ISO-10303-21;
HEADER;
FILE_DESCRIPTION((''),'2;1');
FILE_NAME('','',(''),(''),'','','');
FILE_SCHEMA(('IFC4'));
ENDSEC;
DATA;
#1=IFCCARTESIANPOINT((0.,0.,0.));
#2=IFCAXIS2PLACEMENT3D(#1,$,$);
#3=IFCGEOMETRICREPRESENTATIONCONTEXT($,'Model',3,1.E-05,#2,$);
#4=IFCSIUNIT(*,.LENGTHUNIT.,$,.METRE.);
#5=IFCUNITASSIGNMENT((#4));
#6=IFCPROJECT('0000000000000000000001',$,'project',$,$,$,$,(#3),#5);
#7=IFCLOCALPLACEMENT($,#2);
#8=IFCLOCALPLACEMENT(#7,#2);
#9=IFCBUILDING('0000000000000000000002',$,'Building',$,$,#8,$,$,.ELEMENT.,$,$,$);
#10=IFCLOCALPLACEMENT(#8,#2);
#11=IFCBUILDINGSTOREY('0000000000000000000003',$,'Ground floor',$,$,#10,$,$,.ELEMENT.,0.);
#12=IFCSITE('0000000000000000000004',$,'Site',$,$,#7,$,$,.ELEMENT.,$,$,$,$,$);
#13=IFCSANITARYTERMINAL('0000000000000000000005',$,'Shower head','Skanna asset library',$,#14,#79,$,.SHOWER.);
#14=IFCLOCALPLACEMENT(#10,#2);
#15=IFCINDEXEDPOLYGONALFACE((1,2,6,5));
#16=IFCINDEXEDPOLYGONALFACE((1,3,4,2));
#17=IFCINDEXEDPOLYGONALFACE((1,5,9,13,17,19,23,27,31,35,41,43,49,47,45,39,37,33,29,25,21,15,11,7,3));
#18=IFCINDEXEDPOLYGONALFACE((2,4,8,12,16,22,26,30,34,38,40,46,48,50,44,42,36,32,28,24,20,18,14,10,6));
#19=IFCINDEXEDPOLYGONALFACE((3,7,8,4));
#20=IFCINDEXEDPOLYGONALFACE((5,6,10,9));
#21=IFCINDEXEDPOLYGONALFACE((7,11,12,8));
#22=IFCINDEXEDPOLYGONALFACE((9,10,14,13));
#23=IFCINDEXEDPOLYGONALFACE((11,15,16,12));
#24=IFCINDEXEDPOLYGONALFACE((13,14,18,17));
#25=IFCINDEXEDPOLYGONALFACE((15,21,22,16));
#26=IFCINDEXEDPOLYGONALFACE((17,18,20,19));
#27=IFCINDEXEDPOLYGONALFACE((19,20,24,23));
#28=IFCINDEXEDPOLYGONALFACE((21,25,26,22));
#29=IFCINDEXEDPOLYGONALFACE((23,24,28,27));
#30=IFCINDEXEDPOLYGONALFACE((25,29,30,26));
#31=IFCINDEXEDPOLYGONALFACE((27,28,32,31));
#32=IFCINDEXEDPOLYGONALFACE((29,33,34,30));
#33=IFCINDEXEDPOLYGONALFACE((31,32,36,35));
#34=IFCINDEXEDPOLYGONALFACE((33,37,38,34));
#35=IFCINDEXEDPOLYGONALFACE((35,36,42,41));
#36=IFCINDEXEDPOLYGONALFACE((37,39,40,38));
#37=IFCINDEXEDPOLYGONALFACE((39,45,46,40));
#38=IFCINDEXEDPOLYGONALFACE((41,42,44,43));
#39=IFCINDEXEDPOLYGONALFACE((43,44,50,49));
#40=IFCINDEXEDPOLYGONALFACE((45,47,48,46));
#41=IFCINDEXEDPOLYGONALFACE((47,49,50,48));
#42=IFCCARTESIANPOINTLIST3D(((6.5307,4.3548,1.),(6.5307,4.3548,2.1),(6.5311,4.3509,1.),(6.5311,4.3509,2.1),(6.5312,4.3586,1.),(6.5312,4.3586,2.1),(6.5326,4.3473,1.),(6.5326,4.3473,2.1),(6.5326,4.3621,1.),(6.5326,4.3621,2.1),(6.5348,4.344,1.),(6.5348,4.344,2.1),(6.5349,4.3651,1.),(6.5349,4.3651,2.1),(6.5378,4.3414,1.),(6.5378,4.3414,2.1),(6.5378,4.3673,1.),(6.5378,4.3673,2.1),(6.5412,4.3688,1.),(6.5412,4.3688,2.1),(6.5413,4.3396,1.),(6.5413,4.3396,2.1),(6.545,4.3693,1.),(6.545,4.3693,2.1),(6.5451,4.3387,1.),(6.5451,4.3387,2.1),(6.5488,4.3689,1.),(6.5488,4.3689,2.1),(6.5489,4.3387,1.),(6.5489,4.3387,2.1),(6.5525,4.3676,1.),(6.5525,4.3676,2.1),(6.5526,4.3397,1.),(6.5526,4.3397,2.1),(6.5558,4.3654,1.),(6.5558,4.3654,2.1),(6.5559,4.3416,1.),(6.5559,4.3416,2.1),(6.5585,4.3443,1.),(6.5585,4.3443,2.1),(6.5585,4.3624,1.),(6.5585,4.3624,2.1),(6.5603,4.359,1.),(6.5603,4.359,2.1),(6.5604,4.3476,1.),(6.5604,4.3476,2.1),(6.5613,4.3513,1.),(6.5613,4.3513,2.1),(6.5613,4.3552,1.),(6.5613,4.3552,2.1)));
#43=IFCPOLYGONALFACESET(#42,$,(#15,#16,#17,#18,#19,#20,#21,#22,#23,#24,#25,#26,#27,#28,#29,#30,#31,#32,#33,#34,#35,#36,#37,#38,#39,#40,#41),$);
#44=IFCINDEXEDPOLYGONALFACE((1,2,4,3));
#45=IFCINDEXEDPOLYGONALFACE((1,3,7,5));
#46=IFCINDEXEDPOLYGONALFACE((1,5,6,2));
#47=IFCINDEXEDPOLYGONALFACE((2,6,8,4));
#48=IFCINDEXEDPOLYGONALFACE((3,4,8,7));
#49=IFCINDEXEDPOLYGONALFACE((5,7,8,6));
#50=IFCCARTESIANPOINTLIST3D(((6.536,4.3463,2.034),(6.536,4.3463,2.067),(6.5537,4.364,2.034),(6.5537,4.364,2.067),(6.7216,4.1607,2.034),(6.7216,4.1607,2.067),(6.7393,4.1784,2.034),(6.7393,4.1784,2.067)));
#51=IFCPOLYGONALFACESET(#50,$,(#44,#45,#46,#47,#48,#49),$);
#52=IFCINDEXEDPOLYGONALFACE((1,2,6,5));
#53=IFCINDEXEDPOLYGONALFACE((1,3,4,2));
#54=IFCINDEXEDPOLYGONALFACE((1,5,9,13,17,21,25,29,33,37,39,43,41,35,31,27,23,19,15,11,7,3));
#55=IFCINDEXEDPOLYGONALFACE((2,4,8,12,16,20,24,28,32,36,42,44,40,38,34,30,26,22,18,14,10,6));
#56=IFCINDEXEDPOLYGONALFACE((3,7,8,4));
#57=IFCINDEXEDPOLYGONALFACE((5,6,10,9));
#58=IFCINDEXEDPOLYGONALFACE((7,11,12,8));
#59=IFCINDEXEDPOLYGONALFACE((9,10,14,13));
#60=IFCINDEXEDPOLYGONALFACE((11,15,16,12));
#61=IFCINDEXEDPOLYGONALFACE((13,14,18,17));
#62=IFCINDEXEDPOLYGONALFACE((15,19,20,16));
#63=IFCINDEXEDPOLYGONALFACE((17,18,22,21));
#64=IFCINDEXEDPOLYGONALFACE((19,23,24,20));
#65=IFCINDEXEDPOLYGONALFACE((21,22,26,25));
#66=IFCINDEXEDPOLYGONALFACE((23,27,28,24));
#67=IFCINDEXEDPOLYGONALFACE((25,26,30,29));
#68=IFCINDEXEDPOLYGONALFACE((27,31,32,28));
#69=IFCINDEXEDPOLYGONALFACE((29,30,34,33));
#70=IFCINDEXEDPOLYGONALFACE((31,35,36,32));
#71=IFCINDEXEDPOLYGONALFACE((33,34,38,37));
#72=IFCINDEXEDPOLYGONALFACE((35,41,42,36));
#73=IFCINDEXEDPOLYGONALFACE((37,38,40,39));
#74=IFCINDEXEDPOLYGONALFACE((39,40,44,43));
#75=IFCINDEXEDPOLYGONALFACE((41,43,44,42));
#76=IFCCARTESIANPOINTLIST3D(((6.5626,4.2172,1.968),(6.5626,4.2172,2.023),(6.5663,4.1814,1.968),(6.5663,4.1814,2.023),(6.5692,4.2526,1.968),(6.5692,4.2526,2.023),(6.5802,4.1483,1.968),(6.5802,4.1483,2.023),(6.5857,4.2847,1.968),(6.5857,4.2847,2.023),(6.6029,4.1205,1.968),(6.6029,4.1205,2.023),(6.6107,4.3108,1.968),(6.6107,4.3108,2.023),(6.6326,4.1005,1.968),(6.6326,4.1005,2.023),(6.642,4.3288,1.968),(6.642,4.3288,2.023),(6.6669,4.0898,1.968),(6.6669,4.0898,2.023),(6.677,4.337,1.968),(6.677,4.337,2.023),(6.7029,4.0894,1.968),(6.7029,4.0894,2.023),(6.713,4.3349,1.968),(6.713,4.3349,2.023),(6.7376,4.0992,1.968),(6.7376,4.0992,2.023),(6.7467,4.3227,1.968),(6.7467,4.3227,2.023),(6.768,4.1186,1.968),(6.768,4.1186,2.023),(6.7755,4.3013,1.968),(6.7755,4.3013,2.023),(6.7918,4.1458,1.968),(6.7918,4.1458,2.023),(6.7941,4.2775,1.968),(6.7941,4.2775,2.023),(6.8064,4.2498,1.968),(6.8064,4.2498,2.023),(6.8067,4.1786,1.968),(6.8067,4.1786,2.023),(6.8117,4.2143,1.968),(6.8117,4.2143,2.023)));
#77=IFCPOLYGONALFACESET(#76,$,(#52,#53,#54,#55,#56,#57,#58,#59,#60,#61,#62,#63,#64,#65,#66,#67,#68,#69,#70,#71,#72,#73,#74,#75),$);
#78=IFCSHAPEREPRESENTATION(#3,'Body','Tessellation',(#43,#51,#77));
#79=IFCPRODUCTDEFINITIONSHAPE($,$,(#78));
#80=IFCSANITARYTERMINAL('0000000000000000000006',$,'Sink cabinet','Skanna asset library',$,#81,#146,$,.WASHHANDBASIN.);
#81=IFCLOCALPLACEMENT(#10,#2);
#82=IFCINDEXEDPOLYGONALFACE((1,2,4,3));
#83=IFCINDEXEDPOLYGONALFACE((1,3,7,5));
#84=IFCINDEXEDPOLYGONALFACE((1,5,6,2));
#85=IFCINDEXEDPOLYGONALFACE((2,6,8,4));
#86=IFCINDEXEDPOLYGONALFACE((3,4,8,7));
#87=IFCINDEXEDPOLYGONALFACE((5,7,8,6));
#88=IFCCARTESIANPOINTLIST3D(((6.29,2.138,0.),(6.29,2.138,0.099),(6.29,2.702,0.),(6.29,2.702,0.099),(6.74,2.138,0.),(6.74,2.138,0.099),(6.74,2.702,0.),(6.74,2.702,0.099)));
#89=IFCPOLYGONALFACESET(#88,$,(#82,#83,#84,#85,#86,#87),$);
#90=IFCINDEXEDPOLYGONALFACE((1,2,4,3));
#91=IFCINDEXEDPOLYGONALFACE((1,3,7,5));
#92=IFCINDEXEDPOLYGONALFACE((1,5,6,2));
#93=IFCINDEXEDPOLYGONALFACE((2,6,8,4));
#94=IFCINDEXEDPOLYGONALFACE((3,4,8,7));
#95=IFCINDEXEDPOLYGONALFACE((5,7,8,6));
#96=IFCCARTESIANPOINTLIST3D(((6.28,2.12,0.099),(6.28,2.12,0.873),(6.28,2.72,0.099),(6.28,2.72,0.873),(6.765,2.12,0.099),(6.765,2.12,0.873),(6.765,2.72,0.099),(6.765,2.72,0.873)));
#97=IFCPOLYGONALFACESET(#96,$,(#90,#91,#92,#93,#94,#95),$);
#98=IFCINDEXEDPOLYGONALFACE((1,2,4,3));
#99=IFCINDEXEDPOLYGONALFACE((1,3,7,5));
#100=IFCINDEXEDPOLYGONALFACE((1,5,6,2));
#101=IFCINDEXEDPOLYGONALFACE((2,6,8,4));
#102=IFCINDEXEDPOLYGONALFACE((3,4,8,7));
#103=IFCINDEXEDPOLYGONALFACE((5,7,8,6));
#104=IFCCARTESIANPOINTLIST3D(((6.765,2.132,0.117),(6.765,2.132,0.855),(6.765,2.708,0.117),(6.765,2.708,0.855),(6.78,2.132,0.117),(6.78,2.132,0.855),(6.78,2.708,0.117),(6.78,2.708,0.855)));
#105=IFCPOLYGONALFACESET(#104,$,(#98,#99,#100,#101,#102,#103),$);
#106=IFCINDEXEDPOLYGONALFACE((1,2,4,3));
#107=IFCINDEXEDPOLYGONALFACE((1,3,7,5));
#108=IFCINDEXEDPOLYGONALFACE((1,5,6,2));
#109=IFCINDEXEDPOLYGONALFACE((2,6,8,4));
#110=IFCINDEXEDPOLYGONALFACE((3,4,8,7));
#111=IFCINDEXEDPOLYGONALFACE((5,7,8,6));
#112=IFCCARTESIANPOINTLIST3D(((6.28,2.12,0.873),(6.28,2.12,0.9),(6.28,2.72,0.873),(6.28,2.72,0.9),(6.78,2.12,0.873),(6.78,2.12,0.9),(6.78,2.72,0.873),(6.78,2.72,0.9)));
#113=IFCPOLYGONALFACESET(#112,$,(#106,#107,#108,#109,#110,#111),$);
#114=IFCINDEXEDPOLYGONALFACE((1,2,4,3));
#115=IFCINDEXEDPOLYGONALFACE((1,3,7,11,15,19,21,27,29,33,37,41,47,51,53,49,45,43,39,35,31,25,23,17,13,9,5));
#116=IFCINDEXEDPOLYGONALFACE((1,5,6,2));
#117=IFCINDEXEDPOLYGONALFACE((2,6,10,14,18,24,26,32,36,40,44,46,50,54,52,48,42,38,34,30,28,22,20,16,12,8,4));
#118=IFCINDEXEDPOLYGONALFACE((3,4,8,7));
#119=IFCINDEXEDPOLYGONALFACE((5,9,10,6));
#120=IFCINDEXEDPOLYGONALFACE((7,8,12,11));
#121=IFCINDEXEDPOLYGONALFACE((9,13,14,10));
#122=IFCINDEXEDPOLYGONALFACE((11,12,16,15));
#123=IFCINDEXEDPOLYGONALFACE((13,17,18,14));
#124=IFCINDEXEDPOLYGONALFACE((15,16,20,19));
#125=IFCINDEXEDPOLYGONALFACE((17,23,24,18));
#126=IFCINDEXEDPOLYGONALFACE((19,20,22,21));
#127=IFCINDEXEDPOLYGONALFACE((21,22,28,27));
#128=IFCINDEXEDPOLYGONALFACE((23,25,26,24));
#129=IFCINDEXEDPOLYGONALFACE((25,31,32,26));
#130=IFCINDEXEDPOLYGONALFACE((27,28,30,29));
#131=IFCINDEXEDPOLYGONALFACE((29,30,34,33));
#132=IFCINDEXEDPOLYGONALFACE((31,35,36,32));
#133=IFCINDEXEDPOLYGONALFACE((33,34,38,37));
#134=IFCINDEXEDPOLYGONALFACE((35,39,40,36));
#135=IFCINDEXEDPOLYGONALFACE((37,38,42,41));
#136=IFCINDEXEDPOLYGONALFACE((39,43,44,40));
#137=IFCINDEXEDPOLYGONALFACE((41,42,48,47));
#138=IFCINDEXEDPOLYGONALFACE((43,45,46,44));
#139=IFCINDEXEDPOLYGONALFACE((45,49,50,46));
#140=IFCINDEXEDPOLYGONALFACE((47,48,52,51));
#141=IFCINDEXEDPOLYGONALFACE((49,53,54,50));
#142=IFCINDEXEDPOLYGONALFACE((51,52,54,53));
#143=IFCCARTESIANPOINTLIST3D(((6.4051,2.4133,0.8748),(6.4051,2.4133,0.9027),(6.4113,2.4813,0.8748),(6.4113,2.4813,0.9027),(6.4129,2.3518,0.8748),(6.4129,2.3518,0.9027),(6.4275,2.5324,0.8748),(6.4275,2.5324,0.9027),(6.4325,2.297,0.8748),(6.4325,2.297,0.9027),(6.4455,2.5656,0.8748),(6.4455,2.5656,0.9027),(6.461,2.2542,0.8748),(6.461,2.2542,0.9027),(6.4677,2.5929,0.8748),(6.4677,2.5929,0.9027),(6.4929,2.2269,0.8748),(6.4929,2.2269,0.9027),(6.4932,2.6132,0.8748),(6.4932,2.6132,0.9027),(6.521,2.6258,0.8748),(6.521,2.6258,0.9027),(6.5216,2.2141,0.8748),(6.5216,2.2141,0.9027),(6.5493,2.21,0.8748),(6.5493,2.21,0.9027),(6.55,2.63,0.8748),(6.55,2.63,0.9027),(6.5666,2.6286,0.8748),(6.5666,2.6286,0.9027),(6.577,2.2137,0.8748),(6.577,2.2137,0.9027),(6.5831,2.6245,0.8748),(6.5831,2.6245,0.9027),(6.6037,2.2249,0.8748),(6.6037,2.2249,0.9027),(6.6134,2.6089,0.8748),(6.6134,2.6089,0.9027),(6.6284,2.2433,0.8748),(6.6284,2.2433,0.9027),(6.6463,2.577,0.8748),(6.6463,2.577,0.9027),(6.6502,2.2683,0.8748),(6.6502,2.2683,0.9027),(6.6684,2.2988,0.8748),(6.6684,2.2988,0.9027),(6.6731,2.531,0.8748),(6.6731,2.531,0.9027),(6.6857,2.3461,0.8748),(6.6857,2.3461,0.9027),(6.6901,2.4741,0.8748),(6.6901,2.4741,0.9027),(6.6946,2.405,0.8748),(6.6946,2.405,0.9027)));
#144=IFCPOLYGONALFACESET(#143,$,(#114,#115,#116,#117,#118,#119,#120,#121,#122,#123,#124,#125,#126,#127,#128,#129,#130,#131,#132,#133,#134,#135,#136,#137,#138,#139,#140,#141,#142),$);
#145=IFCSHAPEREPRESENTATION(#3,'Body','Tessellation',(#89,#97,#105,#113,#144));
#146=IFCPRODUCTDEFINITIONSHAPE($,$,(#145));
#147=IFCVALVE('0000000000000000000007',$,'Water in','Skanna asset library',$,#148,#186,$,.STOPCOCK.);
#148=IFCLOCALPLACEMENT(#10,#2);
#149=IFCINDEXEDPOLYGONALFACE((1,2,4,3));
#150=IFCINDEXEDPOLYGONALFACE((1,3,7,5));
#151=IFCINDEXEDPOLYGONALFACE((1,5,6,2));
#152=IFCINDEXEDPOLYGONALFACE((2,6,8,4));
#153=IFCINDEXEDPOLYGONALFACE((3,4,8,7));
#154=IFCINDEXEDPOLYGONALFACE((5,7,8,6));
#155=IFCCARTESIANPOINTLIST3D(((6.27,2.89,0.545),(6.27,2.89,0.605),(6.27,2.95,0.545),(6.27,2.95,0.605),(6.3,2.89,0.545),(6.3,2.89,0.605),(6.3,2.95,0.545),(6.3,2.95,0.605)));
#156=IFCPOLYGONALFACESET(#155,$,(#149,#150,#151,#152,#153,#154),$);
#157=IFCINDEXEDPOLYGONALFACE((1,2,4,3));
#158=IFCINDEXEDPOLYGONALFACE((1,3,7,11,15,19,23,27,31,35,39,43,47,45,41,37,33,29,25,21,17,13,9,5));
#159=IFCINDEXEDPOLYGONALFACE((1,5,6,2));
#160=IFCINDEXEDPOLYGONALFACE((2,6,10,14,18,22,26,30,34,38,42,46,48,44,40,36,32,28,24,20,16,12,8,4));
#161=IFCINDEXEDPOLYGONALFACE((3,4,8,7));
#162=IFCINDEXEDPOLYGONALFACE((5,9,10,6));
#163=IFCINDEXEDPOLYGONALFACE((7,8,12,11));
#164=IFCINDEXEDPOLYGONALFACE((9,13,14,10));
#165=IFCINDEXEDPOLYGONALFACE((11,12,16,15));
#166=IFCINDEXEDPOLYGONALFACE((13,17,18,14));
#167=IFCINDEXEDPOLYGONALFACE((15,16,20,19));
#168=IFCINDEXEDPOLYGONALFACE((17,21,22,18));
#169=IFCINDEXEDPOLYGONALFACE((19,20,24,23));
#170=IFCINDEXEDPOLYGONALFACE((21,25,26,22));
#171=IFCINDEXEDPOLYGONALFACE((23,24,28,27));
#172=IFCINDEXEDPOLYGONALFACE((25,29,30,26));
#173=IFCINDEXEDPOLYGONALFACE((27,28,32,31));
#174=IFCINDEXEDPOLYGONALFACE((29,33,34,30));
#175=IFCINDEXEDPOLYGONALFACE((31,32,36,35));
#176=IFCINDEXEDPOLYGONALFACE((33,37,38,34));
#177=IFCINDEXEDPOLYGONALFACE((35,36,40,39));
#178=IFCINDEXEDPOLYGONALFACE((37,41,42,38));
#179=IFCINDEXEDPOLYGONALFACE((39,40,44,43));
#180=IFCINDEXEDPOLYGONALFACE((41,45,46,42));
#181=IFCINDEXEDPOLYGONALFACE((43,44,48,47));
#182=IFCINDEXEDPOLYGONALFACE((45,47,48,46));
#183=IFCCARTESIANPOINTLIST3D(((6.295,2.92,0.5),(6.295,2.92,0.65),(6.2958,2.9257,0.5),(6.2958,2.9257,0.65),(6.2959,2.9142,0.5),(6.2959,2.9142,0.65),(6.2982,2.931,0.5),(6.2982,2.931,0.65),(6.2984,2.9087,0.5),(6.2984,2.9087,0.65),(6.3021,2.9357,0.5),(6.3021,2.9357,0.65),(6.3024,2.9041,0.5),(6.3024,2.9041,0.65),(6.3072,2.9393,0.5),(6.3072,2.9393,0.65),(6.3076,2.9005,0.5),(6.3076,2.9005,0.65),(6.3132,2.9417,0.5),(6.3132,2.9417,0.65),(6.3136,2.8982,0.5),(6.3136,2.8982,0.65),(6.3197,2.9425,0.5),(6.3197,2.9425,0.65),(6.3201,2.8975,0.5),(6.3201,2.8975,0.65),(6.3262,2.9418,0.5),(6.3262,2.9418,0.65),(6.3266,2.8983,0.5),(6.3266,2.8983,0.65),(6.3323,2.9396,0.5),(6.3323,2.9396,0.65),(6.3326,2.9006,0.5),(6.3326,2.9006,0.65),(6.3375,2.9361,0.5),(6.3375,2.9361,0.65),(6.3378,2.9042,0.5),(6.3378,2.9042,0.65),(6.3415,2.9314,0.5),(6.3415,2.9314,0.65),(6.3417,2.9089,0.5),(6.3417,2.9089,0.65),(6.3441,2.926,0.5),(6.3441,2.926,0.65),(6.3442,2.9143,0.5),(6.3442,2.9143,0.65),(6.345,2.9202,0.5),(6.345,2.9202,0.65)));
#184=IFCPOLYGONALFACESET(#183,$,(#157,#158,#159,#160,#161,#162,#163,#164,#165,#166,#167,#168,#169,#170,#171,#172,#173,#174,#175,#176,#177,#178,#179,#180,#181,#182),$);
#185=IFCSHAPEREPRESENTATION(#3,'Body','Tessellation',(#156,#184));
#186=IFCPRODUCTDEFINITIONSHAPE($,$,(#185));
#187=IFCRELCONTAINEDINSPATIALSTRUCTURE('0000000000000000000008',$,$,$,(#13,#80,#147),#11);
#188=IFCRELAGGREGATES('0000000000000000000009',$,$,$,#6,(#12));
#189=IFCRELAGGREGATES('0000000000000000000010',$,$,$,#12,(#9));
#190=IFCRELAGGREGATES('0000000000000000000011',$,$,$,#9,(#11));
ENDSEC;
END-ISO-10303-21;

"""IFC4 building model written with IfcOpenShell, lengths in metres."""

from ifc_helpers import new_model, si_unit, frame, frame_2d, origin, origin_2d, place, context, project, spatial, rectangle, ellipse, extrude, element, save


model = new_model("IFC4")

# Units and contexts
model_context = context("Model", 3, precision=1e-05, world=origin())
ifc_project = project(units=[si_unit("LENGTHUNIT", "METRE")], contexts=[model_context])

# Site, building, storey
site_placement = place(None, origin())
site = spatial("IfcSite", under=ifc_project, at=site_placement, Name="Site", CompositionType="ELEMENT")
building_placement = place(site_placement, origin())
building = spatial("IfcBuilding", under=site, at=building_placement, Name="Building", CompositionType="ELEMENT")
storey_placement = place(building_placement, origin())
storey = spatial("IfcBuildingStorey", under=building, at=storey_placement, Name="Ground floor", CompositionType="ELEMENT", Elevation=0.0)

# Sanitary terminals
sanitary_terminal_1_placement = place(storey_placement, frame((6.65, 4.25, 1.0), z_axis=(0.0, 0.0, 1.0), x_axis=(0.707107, 0.707107, 0.0)))
element("IfcSanitaryTerminal", 1, at=sanitary_terminal_1_placement, inside=storey, Name="Shower head", Description="Skanna asset library", PredefinedType="SHOWER", context=model_context, shape_type="SweptSolid", body=[
    extrude(ellipse(SemiAxis1=0.015, SemiAxis2=0.0158, at=frame_2d((0.0, 0.147))), origin(), (0.0, 0.0, 1.0), 1.1),
    extrude(rectangle(XDim=0.025, YDim=0.2625, at=frame_2d((0.0, 0.0175))), frame((0.0, 0.0, 1.034)), (0.0, 0.0, 1.0), 0.033),
    extrude(ellipse(SemiAxis1=0.125, SemiAxis2=0.1242, at=frame_2d((0.0, -0.0525))), frame((0.0, 0.0, 0.968)), (0.0, 0.0, 1.0), 0.055),
])
sanitary_terminal_2_placement = place(storey_placement, frame((6.53, 2.42, 0.0), z_axis=(0.0, 0.0, 1.0), x_axis=(0.0, 1.0, 0.0)))
element("IfcSanitaryTerminal", 2, at=sanitary_terminal_2_placement, inside=storey, Name="Sink cabinet", Description="Skanna asset library", PredefinedType="WASHHANDBASIN", context=model_context, shape_type="SweptSolid", body=[
    extrude(rectangle(XDim=0.564, YDim=0.45, at=frame_2d((0.0, 0.015))), origin(), (0.0, 0.0, 1.0), 0.099),
    extrude(rectangle(XDim=0.6, YDim=0.485, at=frame_2d((0.0, 0.0075))), frame((0.0, 0.0, 0.099)), (0.0, 0.0, 1.0), 0.774),
    extrude(rectangle(XDim=0.576, YDim=0.015, at=frame_2d((0.0, -0.2425))), frame((0.0, 0.0, 0.117)), (0.0, 0.0, 1.0), 0.738),
    extrude(rectangle(XDim=0.6, YDim=0.5, at=origin_2d()), frame((0.0, 0.0, 0.873)), (0.0, 0.0, 1.0), 0.027),
    extrude(ellipse(SemiAxis1=0.21, SemiAxis2=0.145, at=frame_2d((0.0, -0.02))), frame((0.0, 0.0, 0.8748)), (0.0, 0.0, 1.0), 0.0279),
])

# Valve
for number, where, z_axis, x_axis, name in (
    (3, (6.32, 2.92, 0.5), (0.0, 0.0, 1.0), (0.0, 1.0, 0.0), "Water in"),
):
    element("IfcValve", number, at=place(storey_placement, frame(where, z_axis=z_axis, x_axis=x_axis)), inside=storey, Name=name, Description="Skanna asset library", PredefinedType="STOPCOCK", context=model_context, shape_type="SweptSolid", body=[
        extrude(rectangle(XDim=0.06, YDim=0.03, at=frame_2d((0.0, 0.035))), frame((0.0, 0.0, 0.045)), (0.0, 0.0, 1.0), 0.06),
        extrude(ellipse(SemiAxis1=0.0225, SemiAxis2=0.025, at=origin_2d()), origin(), (0.0, 0.0, 1.0), 0.15),
    ])

save(model, "model.ifc")
